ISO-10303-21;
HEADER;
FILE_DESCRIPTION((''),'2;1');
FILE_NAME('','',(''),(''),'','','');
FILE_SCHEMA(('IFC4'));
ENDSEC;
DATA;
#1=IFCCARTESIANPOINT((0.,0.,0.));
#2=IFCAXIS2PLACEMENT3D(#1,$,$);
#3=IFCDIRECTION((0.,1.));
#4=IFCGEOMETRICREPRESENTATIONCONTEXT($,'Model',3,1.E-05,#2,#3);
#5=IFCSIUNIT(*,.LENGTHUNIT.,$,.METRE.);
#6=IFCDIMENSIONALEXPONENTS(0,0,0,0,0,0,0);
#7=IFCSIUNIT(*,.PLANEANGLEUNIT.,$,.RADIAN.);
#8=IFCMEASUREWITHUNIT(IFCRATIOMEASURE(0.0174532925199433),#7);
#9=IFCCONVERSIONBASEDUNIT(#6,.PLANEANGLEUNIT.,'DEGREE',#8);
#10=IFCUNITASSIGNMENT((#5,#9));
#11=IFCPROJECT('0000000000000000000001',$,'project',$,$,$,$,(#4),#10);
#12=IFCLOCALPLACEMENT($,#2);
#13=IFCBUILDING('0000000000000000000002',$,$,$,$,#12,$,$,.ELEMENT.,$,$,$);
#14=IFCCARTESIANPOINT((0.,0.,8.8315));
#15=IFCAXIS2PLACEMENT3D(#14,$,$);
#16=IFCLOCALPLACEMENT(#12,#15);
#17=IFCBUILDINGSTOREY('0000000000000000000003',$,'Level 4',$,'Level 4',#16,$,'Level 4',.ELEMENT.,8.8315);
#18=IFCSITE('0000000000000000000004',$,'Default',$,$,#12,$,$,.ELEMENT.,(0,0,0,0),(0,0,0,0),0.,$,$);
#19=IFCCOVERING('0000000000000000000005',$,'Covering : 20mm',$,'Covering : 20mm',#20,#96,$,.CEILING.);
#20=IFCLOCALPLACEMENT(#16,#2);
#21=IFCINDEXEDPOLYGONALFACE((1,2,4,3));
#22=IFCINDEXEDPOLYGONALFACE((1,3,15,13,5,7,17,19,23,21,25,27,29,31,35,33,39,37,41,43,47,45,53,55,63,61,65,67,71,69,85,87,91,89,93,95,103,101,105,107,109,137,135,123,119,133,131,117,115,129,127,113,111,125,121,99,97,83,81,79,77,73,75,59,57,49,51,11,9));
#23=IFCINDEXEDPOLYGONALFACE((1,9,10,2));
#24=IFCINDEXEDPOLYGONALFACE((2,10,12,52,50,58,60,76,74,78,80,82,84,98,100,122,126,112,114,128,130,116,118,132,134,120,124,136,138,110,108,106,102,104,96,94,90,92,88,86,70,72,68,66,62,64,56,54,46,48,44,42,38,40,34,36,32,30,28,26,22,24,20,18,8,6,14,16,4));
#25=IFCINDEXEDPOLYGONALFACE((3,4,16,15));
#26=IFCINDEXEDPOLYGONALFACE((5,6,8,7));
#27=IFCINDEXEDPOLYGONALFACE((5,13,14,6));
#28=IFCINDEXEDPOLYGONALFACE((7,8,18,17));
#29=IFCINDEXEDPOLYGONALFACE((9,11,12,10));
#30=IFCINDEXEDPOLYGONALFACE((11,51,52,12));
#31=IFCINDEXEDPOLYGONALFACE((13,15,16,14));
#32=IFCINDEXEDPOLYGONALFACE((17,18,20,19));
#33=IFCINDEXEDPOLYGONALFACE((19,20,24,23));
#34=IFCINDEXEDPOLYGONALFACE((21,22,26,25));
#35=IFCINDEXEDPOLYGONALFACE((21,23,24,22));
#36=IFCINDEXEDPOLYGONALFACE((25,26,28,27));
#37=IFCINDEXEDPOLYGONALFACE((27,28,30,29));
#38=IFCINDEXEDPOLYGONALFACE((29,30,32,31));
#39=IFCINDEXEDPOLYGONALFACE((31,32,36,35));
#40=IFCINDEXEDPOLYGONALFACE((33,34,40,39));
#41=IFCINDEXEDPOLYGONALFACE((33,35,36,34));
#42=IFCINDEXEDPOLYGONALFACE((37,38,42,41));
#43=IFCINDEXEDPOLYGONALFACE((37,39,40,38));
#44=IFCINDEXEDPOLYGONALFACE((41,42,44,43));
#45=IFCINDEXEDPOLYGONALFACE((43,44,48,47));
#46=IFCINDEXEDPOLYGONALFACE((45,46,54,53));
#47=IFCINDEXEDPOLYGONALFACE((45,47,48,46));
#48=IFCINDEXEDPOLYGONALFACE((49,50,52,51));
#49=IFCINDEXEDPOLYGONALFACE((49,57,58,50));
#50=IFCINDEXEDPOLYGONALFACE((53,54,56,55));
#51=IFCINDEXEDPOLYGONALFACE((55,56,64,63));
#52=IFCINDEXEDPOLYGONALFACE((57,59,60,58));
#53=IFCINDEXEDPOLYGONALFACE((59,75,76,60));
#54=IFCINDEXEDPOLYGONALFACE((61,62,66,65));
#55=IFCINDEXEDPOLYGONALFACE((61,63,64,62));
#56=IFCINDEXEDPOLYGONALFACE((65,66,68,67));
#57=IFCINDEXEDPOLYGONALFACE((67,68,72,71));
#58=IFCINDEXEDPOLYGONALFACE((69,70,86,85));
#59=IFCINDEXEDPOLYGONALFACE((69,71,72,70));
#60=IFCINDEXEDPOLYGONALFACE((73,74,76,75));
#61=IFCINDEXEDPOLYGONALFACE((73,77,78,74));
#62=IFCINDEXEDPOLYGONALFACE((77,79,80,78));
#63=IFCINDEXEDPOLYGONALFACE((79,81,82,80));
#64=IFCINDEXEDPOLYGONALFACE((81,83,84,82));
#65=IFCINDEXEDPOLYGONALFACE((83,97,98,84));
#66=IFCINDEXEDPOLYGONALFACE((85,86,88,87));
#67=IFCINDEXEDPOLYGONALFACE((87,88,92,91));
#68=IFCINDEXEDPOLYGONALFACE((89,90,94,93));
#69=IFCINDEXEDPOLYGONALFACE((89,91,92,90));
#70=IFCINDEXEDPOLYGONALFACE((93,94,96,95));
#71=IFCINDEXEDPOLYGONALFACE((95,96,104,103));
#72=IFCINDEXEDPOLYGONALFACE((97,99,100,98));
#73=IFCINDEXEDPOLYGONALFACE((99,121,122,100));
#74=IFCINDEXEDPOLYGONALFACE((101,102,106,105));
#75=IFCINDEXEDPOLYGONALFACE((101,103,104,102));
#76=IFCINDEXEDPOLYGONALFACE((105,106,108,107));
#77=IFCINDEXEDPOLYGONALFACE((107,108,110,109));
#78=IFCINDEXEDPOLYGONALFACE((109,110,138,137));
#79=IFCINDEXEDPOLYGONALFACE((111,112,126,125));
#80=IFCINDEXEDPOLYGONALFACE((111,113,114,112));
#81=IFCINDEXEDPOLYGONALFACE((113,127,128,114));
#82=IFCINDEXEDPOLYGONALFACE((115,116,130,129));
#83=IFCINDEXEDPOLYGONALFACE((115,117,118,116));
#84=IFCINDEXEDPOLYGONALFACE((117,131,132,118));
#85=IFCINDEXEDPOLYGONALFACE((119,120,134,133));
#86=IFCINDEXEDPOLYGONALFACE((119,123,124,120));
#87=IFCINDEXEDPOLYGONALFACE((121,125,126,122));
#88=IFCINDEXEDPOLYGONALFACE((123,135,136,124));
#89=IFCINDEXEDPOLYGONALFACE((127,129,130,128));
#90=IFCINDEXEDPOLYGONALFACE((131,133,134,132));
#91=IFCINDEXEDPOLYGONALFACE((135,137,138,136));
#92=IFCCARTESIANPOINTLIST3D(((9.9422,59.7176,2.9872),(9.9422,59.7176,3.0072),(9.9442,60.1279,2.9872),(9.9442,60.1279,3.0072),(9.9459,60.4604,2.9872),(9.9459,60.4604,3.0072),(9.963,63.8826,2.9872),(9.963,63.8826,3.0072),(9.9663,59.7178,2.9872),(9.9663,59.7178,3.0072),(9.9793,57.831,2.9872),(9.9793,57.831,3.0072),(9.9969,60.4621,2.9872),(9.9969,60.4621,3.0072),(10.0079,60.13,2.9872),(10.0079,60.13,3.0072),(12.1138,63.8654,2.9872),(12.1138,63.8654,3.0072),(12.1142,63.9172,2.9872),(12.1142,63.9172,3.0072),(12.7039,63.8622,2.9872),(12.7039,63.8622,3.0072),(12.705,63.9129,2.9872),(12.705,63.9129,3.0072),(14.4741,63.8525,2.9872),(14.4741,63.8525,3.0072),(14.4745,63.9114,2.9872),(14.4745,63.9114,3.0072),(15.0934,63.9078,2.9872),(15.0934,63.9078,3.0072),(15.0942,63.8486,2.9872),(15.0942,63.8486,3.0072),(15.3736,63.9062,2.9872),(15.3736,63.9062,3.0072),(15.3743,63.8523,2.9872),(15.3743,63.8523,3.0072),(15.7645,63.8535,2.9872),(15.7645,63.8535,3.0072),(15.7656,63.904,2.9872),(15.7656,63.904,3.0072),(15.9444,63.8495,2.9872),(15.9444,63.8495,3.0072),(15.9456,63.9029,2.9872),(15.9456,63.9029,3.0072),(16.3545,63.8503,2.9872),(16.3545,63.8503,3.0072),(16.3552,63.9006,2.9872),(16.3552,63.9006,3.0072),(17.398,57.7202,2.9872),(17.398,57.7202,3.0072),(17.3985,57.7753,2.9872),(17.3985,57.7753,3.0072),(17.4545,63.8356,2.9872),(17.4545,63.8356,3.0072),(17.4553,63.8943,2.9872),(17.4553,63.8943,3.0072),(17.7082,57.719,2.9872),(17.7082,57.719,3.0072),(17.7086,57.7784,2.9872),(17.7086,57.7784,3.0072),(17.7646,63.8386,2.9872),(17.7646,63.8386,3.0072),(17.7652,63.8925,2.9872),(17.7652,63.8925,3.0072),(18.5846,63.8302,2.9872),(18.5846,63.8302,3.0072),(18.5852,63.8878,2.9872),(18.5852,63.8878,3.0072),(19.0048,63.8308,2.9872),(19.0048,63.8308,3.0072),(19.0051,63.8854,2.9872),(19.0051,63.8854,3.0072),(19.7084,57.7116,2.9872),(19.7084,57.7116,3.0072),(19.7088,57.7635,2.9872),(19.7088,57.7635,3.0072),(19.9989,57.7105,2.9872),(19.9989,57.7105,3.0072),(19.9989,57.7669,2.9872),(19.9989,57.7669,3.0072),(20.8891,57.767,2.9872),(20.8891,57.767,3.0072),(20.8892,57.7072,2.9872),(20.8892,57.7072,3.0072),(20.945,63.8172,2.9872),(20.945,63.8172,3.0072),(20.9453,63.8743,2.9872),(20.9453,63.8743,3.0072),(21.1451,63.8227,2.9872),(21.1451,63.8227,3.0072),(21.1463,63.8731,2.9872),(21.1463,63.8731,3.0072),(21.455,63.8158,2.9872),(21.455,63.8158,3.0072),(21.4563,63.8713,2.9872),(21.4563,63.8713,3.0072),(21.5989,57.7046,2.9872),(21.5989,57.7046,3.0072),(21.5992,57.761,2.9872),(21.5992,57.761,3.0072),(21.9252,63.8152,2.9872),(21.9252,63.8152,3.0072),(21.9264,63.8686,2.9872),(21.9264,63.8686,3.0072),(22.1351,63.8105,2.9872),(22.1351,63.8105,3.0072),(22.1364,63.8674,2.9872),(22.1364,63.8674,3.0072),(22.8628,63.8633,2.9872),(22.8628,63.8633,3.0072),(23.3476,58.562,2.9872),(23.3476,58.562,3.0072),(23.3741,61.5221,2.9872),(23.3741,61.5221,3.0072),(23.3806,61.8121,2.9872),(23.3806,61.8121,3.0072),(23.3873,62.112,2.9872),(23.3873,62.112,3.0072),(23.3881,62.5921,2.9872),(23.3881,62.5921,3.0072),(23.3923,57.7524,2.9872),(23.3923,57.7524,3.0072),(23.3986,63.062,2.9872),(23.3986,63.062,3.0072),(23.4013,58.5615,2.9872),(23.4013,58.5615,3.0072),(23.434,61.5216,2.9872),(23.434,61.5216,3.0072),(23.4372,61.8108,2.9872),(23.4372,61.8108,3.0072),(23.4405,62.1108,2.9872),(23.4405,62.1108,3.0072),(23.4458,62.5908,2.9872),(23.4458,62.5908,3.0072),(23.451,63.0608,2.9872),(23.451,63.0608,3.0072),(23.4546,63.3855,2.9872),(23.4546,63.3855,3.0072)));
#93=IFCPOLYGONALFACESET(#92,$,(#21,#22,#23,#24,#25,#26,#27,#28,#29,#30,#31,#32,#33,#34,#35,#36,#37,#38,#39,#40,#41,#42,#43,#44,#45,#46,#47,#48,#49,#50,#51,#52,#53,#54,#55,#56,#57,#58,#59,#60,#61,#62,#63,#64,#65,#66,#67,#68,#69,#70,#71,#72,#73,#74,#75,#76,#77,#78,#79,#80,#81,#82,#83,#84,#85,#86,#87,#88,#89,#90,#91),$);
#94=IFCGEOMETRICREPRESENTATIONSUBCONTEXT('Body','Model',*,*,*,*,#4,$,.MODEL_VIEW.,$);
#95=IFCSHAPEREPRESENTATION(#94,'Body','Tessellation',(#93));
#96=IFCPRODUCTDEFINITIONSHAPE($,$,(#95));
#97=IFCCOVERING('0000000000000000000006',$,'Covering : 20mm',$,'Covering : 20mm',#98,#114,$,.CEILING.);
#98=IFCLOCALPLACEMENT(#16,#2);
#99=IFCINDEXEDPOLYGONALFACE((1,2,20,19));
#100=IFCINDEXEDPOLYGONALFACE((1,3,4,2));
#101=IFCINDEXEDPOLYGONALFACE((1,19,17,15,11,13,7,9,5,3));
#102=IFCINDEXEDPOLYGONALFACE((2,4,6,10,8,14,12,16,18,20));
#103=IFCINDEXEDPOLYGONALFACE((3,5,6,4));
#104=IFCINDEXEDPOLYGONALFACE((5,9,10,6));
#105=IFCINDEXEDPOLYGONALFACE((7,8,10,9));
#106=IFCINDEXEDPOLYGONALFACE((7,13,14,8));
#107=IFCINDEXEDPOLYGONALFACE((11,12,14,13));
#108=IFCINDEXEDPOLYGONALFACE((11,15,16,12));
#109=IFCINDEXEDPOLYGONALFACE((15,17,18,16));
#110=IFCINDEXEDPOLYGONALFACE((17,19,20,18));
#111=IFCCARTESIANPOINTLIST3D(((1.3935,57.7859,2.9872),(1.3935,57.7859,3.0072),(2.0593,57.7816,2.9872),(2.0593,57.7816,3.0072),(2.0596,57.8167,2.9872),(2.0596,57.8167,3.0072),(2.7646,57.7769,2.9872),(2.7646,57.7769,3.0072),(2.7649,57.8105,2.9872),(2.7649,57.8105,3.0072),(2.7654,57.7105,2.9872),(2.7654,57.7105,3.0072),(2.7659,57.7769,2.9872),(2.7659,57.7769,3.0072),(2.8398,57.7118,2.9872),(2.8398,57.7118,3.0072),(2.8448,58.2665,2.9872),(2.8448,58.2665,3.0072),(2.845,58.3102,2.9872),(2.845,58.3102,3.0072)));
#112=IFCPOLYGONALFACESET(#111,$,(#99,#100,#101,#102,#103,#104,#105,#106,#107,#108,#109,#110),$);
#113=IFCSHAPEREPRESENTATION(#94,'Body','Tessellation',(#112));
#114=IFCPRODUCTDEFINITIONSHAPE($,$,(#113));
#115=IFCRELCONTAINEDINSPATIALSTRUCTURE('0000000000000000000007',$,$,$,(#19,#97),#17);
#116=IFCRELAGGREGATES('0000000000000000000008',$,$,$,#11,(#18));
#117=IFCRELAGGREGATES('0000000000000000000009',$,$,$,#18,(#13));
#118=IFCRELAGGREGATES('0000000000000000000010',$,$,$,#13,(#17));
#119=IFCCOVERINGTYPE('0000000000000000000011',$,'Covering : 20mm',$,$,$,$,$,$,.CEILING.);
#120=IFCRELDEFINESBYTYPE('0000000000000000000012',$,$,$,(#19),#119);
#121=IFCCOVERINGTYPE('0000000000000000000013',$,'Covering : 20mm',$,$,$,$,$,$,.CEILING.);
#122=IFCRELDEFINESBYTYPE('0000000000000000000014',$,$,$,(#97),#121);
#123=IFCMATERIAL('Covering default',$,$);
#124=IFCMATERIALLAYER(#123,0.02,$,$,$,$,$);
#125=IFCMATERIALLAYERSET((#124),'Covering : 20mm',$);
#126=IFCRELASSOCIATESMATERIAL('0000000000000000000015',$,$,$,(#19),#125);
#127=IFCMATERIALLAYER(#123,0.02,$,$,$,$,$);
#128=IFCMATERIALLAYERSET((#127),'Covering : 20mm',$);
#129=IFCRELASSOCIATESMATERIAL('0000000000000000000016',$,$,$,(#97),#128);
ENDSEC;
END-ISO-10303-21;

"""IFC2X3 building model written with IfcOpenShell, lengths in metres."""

from ifc_helpers import new_model, entity, si_unit, converted_unit, direction, frame, origin, origin_with_axes, place, context, subcontext, project, spatial, polyline, outline, extrude, material, layer, layer_set, layer_usage, type_object, element, save


model = new_model("IFC2X3")

# Units and contexts
model_context = context("Model", 3, precision=1e-05, world=origin(), true_north=direction((0.0, 1.0)))
body_context = subcontext(model_context, "Body", "Model", "MODEL_VIEW")
ifc_project = project(units=[si_unit("LENGTHUNIT", "METRE"), converted_unit("PLANEANGLEUNIT", "DEGREE", entity("IfcRatioMeasure", 0.0174532925199433), si_unit("PLANEANGLEUNIT", "RADIAN"), dimensions=[0, 0, 0, 0, 0, 0, 0])], contexts=[model_context])

# Site, building, storey
placement = place(None, origin())
site = spatial("IfcSite", under=ifc_project, at=placement, Name="Default", CompositionType="ELEMENT", RefLatitude=(0, 0, 0, 0), RefLongitude=(0, 0, 0, 0), RefElevation=0.0)
building = spatial("IfcBuilding", under=site, at=placement, CompositionType="ELEMENT")
storey_placement = place(placement, frame((0.0, 0.0, 8.8315)))
storey = spatial("IfcBuildingStorey", under=building, at=storey_placement, Name="Level 4", ObjectType="Level 4", LongName="Level 4", CompositionType="ELEMENT", Elevation=8.8315)

# Coverings
ifc_material_1 = material(Name="Covering default")
ifc_layer_1 = layer(ifc_material_1, 0.02)
ifc_layer_set_1 = layer_set([ifc_layer_1], Name="Covering : 20mm")
ifc_layer_usage_1 = layer_usage(ifc_layer_set_1, "AXIS3", "POSITIVE", 0.0)
covering_type_1 = type_object("IfcCoveringType", Name="Covering : 20mm", PredefinedType="CEILING")
covering_1_placement = place(placement, frame((0.0, 0.0, 11.8187)))
element("IfcCovering", 1, at=covering_1_placement, inside=storey, type_object=covering_type_1, material=ifc_layer_usage_1, Name="Covering : 20mm", ObjectType="Covering : 20mm", PredefinedType="CEILING", context=body_context, shape_type="SweptSolid", body=[
    extrude(outline(polyline([(9.9442, 60.1279), (10.0079, 60.13), (9.9969, 60.4621), (9.9459, 60.4604), (9.963, 63.8826), (12.1138, 63.8654), (12.1142, 63.9172), (12.705, 63.9129), (12.7039, 63.8622), (14.4741, 63.8525), (14.4745, 63.9114), (15.0934, 63.9078), (15.0942, 63.8486), (15.3743, 63.8523), (15.3736, 63.9062), (15.7656, 63.904), (15.7645, 63.8535), (15.9444, 63.8495), (15.9456, 63.9029), (16.3552, 63.9006), (16.3545, 63.8503), (17.4545, 63.8356), (17.4553, 63.8943), (17.7652, 63.8925), (17.7646, 63.8386), (18.5846, 63.8302), (18.5852, 63.8878), (19.0051, 63.8854), (19.0048, 63.8308), (20.945, 63.8172), (20.9453, 63.8743), (21.1463, 63.8731), (21.1451, 63.8227), (21.455, 63.8158), (21.4563, 63.8713), (21.9264, 63.8686), (21.9252, 63.8152), (22.1351, 63.8105), (22.1364, 63.8674), (22.8628, 63.8633), (23.4546, 63.3855), (23.451, 63.0608), (23.3986, 63.062), (23.3881, 62.5921), (23.4458, 62.5908), (23.4405, 62.1108), (23.3873, 62.112), (23.3806, 61.8121), (23.4372, 61.8108), (23.434, 61.5216), (23.3741, 61.5221), (23.3476, 58.562), (23.4013, 58.5615), (23.3923, 57.7524), (21.5992, 57.761), (21.5989, 57.7046), (20.8892, 57.7072), (20.8891, 57.767), (19.9989, 57.7669), (19.9989, 57.7105), (19.7084, 57.7116), (19.7088, 57.7635), (17.7086, 57.7784), (17.7082, 57.719), (17.398, 57.7202), (17.3985, 57.7753), (9.9793, 57.831), (9.9663, 59.7178), (9.9422, 59.7176), (9.9442, 60.1279)])), origin_with_axes(), (0.0, 0.0, 1.0), 0.02),
])
ifc_layer_2 = layer(ifc_material_1, 0.02)
ifc_layer_set_2 = layer_set([ifc_layer_2], Name="Covering : 20mm")
ifc_layer_usage_2 = layer_usage(ifc_layer_set_2, "AXIS3", "POSITIVE", 0.0)
covering_type_2 = type_object("IfcCoveringType", Name="Covering : 20mm", PredefinedType="CEILING")
covering_2_placement = place(placement, frame((0.0, 0.0, 11.8187)))
element("IfcCovering", 2, at=covering_2_placement, inside=storey, type_object=covering_type_2, material=ifc_layer_usage_2, Name="Covering : 20mm", ObjectType="Covering : 20mm", PredefinedType="CEILING", context=body_context, shape_type="SweptSolid", body=[
    extrude(outline(polyline([(1.3935, 57.7859), (2.845, 58.3102), (2.8448, 58.2665), (2.8398, 57.7118), (2.7654, 57.7105), (2.7659, 57.7769), (2.7646, 57.7769), (2.7649, 57.8105), (2.0596, 57.8167), (2.0593, 57.7816), (1.3935, 57.7859)])), origin_with_axes(), (0.0, 0.0, 1.0), 0.02),
])

save(model, "model.ifc")
